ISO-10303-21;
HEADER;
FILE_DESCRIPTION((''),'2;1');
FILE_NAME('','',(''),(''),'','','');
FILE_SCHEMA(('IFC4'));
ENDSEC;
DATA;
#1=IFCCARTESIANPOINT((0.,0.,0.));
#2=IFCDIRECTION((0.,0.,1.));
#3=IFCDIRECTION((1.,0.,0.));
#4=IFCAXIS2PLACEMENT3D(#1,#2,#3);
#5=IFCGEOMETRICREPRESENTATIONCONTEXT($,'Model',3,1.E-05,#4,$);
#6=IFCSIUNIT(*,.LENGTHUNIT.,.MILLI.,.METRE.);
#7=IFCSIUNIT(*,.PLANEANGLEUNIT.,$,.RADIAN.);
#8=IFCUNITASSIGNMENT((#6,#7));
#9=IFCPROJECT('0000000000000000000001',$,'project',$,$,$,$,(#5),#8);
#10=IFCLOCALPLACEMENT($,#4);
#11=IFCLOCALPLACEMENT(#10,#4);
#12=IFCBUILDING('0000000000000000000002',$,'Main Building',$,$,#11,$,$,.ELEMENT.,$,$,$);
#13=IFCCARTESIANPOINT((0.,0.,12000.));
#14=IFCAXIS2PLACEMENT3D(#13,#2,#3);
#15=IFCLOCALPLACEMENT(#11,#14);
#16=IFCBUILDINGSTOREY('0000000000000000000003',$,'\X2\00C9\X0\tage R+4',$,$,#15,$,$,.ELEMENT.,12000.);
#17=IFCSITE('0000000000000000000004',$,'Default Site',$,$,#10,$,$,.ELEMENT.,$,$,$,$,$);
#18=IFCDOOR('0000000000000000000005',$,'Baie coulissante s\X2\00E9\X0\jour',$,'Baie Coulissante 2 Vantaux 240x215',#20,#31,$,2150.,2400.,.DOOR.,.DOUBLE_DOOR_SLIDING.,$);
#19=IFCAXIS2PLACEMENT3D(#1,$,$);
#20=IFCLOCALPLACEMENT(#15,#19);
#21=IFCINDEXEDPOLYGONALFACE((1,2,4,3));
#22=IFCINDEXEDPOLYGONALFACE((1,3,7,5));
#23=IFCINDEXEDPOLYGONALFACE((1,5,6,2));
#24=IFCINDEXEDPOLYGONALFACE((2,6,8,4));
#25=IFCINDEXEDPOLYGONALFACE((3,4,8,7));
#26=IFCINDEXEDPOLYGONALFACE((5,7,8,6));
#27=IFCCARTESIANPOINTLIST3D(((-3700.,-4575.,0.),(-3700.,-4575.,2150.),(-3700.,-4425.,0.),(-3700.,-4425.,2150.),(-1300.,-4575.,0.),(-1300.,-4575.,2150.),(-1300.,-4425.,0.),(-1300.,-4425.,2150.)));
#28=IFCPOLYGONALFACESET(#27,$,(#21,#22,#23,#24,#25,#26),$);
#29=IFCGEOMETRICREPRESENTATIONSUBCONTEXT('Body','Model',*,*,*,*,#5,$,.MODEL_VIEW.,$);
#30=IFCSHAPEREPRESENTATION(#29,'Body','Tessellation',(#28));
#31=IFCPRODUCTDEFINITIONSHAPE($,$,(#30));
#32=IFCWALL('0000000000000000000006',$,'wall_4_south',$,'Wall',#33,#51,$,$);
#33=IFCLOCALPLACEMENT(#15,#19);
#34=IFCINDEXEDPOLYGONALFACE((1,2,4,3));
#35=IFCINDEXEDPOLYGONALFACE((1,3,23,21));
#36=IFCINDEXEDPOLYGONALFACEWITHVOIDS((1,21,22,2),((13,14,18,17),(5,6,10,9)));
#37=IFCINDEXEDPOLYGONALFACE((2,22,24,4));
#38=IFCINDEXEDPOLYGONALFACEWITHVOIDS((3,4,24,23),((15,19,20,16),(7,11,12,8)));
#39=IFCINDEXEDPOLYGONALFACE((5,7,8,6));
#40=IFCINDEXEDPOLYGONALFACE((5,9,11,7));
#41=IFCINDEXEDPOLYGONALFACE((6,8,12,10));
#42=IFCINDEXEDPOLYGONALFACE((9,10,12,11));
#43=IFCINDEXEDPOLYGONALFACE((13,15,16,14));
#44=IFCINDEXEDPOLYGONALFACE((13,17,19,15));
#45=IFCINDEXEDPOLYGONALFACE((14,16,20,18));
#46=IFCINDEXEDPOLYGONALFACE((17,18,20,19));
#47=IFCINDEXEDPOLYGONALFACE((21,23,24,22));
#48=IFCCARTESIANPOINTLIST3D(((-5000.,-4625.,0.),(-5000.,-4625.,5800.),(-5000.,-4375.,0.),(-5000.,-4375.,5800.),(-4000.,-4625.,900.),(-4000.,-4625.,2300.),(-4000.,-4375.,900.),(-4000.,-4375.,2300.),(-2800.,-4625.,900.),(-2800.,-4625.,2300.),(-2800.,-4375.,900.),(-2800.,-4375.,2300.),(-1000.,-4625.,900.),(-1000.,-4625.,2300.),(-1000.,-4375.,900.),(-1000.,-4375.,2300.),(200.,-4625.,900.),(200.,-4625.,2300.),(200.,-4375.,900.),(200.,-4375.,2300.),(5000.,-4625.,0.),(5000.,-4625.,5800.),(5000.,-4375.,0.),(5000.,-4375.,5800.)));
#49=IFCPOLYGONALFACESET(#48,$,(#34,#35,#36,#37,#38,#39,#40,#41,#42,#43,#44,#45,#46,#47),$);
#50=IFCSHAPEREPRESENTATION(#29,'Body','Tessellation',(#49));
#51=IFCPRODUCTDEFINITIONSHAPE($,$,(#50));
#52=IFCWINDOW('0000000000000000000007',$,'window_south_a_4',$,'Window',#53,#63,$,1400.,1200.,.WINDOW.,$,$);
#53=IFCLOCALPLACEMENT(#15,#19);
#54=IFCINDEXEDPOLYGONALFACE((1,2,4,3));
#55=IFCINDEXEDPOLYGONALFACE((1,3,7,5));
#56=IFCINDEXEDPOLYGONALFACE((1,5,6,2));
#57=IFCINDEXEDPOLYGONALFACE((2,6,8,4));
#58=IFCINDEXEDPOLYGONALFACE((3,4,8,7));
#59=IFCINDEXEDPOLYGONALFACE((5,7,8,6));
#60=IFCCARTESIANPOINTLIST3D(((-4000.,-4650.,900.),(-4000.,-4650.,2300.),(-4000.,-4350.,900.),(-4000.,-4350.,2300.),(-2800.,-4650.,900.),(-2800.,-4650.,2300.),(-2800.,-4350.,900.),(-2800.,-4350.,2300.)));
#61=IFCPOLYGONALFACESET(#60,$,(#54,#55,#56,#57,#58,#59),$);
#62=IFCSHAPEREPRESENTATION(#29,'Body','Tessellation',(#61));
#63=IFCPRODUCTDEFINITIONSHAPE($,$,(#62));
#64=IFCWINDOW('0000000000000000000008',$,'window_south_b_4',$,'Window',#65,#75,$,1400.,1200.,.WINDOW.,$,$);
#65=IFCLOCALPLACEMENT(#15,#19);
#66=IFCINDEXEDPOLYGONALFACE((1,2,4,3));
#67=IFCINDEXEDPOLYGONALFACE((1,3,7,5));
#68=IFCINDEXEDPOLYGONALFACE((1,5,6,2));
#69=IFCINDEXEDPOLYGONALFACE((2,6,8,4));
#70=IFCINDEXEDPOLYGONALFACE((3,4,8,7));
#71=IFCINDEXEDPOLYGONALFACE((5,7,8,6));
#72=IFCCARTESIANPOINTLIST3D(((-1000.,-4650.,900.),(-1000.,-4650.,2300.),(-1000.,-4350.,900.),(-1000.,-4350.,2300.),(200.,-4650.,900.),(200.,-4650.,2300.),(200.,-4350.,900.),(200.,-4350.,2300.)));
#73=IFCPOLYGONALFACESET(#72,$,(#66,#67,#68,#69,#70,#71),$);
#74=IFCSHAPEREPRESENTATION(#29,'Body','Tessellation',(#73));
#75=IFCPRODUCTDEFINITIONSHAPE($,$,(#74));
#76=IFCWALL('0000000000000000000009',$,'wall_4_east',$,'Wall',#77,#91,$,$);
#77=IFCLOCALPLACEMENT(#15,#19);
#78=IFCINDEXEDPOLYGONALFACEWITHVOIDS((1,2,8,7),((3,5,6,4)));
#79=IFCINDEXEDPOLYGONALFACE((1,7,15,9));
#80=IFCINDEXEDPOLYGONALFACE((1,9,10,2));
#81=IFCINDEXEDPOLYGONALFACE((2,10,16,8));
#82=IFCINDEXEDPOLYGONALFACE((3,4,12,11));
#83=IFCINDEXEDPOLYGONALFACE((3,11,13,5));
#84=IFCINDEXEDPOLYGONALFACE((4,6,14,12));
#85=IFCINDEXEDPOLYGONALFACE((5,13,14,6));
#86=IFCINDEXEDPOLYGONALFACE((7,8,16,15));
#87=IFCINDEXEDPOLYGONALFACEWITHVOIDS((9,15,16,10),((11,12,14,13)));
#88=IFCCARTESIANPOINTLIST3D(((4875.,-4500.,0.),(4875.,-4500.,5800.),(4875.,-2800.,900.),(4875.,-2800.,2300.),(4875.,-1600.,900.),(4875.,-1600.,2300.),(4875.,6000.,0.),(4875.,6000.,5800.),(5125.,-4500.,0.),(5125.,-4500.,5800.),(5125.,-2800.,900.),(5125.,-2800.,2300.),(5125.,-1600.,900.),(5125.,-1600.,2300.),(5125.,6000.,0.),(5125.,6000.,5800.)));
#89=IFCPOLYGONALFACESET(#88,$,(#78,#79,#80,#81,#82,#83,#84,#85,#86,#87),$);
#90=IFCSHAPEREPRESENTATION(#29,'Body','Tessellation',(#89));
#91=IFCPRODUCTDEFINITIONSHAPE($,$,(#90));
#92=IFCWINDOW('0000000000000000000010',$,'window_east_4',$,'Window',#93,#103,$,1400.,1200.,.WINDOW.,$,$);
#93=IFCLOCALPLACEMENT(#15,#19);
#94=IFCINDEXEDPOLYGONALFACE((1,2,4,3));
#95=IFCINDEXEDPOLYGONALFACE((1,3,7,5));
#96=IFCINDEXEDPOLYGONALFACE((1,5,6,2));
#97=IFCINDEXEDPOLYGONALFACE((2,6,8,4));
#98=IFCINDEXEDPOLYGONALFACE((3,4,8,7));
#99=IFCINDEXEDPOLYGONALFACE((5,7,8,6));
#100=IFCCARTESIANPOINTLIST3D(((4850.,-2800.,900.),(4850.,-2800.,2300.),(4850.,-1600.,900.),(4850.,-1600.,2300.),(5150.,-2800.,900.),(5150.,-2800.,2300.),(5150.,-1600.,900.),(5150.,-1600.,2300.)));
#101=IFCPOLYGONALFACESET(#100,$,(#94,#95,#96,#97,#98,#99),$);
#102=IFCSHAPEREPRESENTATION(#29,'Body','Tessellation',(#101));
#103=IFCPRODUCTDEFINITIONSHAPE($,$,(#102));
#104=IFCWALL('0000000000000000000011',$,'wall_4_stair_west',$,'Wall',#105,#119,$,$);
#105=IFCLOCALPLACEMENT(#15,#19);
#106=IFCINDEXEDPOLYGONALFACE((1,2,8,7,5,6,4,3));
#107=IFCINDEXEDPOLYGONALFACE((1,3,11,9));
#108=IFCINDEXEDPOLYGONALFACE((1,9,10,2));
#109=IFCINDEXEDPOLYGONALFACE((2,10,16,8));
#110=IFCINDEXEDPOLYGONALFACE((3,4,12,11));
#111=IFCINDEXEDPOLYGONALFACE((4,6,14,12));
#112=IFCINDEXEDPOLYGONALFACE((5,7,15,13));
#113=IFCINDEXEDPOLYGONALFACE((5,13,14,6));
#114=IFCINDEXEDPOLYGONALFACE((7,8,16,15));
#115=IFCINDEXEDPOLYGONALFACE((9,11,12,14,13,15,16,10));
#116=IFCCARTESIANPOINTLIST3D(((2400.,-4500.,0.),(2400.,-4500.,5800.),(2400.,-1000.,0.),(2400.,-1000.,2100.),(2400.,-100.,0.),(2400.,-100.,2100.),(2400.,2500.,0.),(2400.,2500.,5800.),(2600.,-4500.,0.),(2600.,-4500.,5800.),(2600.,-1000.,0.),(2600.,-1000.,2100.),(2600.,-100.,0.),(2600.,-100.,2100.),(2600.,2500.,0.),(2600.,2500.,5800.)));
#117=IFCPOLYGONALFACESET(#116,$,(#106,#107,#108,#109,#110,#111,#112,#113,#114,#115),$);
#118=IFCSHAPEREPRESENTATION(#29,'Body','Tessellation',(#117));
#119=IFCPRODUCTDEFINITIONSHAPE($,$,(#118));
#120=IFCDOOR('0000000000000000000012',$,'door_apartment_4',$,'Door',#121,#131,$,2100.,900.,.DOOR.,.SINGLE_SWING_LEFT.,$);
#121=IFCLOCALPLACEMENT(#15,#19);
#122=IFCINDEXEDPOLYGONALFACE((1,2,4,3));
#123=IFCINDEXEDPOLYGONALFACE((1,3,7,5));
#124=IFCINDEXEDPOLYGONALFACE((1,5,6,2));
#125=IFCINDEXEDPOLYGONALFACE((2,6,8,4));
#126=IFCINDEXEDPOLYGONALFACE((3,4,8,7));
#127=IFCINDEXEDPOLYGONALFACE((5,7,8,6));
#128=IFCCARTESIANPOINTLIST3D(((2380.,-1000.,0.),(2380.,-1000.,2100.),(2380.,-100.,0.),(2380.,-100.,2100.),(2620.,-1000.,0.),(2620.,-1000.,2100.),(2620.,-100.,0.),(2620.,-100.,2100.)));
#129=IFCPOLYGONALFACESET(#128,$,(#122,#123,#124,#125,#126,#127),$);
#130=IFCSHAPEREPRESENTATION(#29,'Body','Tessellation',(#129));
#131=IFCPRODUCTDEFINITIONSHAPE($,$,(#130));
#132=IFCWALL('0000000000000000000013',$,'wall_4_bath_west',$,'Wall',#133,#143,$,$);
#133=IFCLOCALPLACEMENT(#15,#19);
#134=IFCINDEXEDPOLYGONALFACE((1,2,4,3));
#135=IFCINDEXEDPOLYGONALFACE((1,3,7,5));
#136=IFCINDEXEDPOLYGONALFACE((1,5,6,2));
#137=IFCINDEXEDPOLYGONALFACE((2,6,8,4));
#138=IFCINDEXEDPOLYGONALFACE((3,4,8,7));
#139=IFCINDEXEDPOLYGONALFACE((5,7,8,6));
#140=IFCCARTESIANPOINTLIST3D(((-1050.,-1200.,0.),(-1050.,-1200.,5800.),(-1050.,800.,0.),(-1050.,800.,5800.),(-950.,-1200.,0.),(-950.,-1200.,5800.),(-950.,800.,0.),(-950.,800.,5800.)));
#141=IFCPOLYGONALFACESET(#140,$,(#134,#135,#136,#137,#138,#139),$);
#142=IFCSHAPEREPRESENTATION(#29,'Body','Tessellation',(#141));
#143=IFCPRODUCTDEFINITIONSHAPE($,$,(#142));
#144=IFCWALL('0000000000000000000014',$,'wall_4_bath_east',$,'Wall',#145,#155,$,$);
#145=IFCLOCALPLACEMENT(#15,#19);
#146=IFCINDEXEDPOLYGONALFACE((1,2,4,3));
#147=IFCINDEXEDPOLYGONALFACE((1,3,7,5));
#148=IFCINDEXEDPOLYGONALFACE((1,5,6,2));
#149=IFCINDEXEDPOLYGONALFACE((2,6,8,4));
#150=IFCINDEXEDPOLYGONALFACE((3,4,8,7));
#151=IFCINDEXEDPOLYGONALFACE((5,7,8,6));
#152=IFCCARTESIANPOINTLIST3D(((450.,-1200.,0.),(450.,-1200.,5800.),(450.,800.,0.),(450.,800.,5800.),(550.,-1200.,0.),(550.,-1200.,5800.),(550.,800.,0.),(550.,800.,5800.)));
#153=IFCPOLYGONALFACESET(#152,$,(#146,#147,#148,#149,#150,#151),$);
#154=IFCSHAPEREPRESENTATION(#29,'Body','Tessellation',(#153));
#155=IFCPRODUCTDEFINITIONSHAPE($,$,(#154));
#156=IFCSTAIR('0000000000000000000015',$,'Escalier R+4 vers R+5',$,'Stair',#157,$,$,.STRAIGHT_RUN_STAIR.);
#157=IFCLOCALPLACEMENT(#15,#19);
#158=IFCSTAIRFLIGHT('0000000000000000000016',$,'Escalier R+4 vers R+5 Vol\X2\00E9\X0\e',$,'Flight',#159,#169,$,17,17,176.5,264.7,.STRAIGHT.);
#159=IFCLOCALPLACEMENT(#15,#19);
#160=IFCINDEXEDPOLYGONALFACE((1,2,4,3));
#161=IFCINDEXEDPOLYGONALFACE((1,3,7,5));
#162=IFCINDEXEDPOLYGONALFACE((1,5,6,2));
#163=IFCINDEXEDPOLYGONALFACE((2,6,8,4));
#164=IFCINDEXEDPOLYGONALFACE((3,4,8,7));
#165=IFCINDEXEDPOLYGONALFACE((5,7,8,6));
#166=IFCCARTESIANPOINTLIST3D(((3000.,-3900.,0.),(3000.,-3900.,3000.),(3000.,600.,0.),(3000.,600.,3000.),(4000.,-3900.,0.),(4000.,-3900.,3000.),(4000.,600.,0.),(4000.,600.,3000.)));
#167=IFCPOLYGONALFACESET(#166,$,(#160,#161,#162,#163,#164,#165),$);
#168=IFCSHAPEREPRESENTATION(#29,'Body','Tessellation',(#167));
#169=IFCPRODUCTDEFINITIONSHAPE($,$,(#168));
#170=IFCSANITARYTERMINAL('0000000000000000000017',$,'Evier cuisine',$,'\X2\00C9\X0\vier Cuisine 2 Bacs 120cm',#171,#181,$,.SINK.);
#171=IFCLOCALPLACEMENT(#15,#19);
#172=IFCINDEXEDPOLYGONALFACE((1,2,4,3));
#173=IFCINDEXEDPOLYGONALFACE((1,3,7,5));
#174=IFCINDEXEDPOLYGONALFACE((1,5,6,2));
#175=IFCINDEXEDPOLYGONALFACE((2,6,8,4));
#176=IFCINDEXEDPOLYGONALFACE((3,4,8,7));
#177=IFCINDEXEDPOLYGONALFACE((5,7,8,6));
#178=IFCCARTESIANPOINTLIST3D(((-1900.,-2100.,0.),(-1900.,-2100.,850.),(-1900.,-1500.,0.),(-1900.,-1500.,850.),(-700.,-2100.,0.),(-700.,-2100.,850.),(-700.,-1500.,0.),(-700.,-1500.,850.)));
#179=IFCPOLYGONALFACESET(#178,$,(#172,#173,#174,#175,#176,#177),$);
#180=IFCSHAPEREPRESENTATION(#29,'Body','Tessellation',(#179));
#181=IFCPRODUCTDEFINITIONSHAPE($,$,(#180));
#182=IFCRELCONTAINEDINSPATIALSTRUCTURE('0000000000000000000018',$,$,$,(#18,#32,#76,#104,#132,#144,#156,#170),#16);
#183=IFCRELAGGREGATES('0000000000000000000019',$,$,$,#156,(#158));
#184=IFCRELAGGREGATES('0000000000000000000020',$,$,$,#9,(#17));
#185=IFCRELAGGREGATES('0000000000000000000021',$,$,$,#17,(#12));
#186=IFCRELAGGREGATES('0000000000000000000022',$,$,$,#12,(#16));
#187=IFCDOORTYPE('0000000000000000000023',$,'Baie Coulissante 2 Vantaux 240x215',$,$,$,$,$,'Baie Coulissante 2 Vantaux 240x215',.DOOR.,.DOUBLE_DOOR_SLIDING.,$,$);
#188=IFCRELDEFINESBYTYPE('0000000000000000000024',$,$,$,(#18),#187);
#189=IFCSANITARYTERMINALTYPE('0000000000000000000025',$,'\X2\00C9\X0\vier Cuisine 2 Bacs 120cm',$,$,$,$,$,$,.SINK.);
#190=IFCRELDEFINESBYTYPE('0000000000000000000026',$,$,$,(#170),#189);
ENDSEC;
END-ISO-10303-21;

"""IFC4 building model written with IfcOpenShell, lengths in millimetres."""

from ifc_helpers import new_model, si_unit, frame, origin_with_axes, place, context, subcontext, project, spatial, polyline, outline, extrude, type_object, element, fill, aggregate, save


model = new_model("IFC4")

# Units and contexts
model_context = context("Model", 3, precision=1e-05, world=origin_with_axes())
body_context = subcontext(model_context, "Body", "Model", "MODEL_VIEW")
ifc_project = project(units=[si_unit("LENGTHUNIT", "METRE", prefix="MILLI"), si_unit("PLANEANGLEUNIT", "RADIAN")], contexts=[model_context])

# Site, building, storey
site_placement = place(None, origin_with_axes())
site = spatial("IfcSite", under=ifc_project, at=site_placement, Name="Default Site", CompositionType="ELEMENT")
building_placement = place(site_placement, origin_with_axes())
building = spatial("IfcBuilding", under=site, at=building_placement, Name="Main Building", CompositionType="ELEMENT")
storey_placement = place(building_placement, frame((0.0, 0.0, 12000.0), z_axis=(0.0, 0.0, 1.0), x_axis=(1.0, 0.0, 0.0)))
storey = spatial("IfcBuildingStorey", under=building, at=storey_placement, Name="Étage R+4", CompositionType="ELEMENT", Elevation=12000.0)

# Door
door_type = type_object("IfcDoorType", Name="Baie Coulissante 2 Vantaux 240x215", ElementType="Baie Coulissante 2 Vantaux 240x215", OperationType="DOUBLE_DOOR_SLIDING", PredefinedType="DOOR")
door_1_placement = place(storey_placement, frame((-2500.0, -4500.0, 0.0), z_axis=(0.0, 0.0, 1.0), x_axis=(1.0, 0.0, 0.0)))
element("IfcDoor", 1, at=door_1_placement, inside=storey, type_object=door_type, Name="Baie coulissante séjour", ObjectType="Baie Coulissante 2 Vantaux 240x215", OperationType="DOUBLE_DOOR_SLIDING", OverallHeight=2150.0, OverallWidth=2400.0, PredefinedType="DOOR", context=body_context, shape_type="SweptSolid", body=[
    extrude(outline(polyline([(-1200.0, -75.0), (1200.0, -75.0), (1200.0, 75.0), (-1200.0, 75.0), (-1200.0, -75.0)])), origin_with_axes(), (0.0, 0.0, 1.0), 2150.0),
])

# Wall, openings, windows
wall_1_placement = place(storey_placement, frame((-5000.0, -4500.0, 0.0), z_axis=(0.0, 0.0, 1.0), x_axis=(1.0, 0.0, 0.0)))
wall_1 = element("IfcWall", 2, at=wall_1_placement, inside=storey, Name="wall_4_south", ObjectType="Wall", context=body_context, shape_type="SweptSolid", body=[
    extrude(outline(polyline([(0.0, -125.0), (10000.0, -125.0), (10000.0, 125.0), (0.0, 125.0), (0.0, -125.0)])), origin_with_axes(), (0.0, 0.0, 1.0), 5800.0),
])
placement_1 = place(wall_1_placement, frame((1000.0, 0.0, 900.0), z_axis=(0.0, 0.0, 1.0), x_axis=(1.0, 0.0, 0.0)))
opening_1 = element("IfcOpeningElement", 3, at=placement_1, cuts=wall_1, PredefinedType="OPENING", context=body_context, shape_type="SweptSolid", body=[
    extrude(outline(polyline([(0.0, -150.0), (1200.0, -150.0), (1200.0, 150.0), (0.0, 150.0), (0.0, -150.0)])), origin_with_axes(), (0.0, 0.0, 1.0), 1400.0),
])
placement_2 = place(wall_1_placement, frame((4000.0, 0.0, 900.0), z_axis=(0.0, 0.0, 1.0), x_axis=(1.0, 0.0, 0.0)))
opening_2 = element("IfcOpeningElement", 4, at=placement_2, cuts=wall_1, PredefinedType="OPENING", context=body_context, shape_type="SweptSolid", body=[
    extrude(outline(polyline([(0.0, -150.0), (1200.0, -150.0), (1200.0, 150.0), (0.0, 150.0), (0.0, -150.0)])), origin_with_axes(), (0.0, 0.0, 1.0), 1400.0),
])
window_1 = element("IfcWindow", 5, at=placement_1, Name="window_south_a_4", ObjectType="Window", OverallHeight=1400.0, OverallWidth=1200.0, PredefinedType="WINDOW", context=body_context, shape_type="SweptSolid", body=[
    extrude(outline(polyline([(0.0, -150.0), (1200.0, -150.0), (1200.0, 150.0), (0.0, 150.0), (0.0, -150.0)])), origin_with_axes(), (0.0, 0.0, 1.0), 1400.0),
])
fill(opening_1, window_1)
window_2 = element("IfcWindow", 6, at=placement_2, Name="window_south_b_4", ObjectType="Window", OverallHeight=1400.0, OverallWidth=1200.0, PredefinedType="WINDOW", context=body_context, shape_type="SweptSolid", body=[
    extrude(outline(polyline([(0.0, -150.0), (1200.0, -150.0), (1200.0, 150.0), (0.0, 150.0), (0.0, -150.0)])), origin_with_axes(), (0.0, 0.0, 1.0), 1400.0),
])
fill(opening_2, window_2)

# Wall, opening, window
wall_2_placement = place(storey_placement, frame((5000.0, -4500.0, 0.0), z_axis=(0.0, 0.0, 1.0), x_axis=(0.0, 1.0, 0.0)))
wall_2 = element("IfcWall", 7, at=wall_2_placement, inside=storey, Name="wall_4_east", ObjectType="Wall", context=body_context, shape_type="SweptSolid", body=[
    extrude(outline(polyline([(0.0, -125.0), (10500.0, -125.0), (10500.0, 125.0), (0.0, 125.0), (0.0, -125.0)])), origin_with_axes(), (0.0, 0.0, 1.0), 5800.0),
])
placement_3 = place(wall_2_placement, frame((1700.0, 0.0, 900.0), z_axis=(0.0, 0.0, 1.0), x_axis=(1.0, 0.0, 0.0)))
opening_3 = element("IfcOpeningElement", 8, at=placement_3, cuts=wall_2, PredefinedType="OPENING", context=body_context, shape_type="SweptSolid", body=[
    extrude(outline(polyline([(0.0, -150.0), (1200.0, -150.0), (1200.0, 150.0), (0.0, 150.0), (0.0, -150.0)])), origin_with_axes(), (0.0, 0.0, 1.0), 1400.0),
])
window_3 = element("IfcWindow", 9, at=placement_3, Name="window_east_4", ObjectType="Window", OverallHeight=1400.0, OverallWidth=1200.0, PredefinedType="WINDOW", context=body_context, shape_type="SweptSolid", body=[
    extrude(outline(polyline([(0.0, -150.0), (1200.0, -150.0), (1200.0, 150.0), (0.0, 150.0), (0.0, -150.0)])), origin_with_axes(), (0.0, 0.0, 1.0), 1400.0),
])
fill(opening_3, window_3)

# Wall, opening, door
wall_3_placement = place(storey_placement, frame((2500.0, -4500.0, 0.0), z_axis=(0.0, 0.0, 1.0), x_axis=(0.0, 1.0, 0.0)))
wall_3 = element("IfcWall", 10, at=wall_3_placement, inside=storey, Name="wall_4_stair_west", ObjectType="Wall", context=body_context, shape_type="SweptSolid", body=[
    extrude(outline(polyline([(0.0, -100.0), (7000.0, -100.0), (7000.0, 100.0), (0.0, 100.0), (0.0, -100.0)])), origin_with_axes(), (0.0, 0.0, 1.0), 5800.0),
])
placement_4 = place(wall_3_placement, frame((3500.0, 0.0, 0.0), z_axis=(0.0, 0.0, 1.0), x_axis=(1.0, 0.0, 0.0)))
opening_4 = element("IfcOpeningElement", 11, at=placement_4, cuts=wall_3, PredefinedType="OPENING", context=body_context, shape_type="SweptSolid", body=[
    extrude(outline(polyline([(0.0, -120.0), (900.0, -120.0), (900.0, 120.0), (0.0, 120.0), (0.0, -120.0)])), origin_with_axes(), (0.0, 0.0, 1.0), 2100.0),
])
door_2 = element("IfcDoor", 12, at=placement_4, Name="door_apartment_4", ObjectType="Door", OperationType="SINGLE_SWING_LEFT", OverallHeight=2100.0, OverallWidth=900.0, PredefinedType="DOOR", context=body_context, shape_type="SweptSolid", body=[
    extrude(outline(polyline([(0.0, -120.0), (900.0, -120.0), (900.0, 120.0), (0.0, 120.0), (0.0, -120.0)])), origin_with_axes(), (0.0, 0.0, 1.0), 2100.0),
])
fill(opening_4, door_2)

# Walls
for number, where, z_axis, x_axis, name in (
    (13, (-1000.0, -1200.0, 0.0), (0.0, 0.0, 1.0), (0.0, 1.0, 0.0), "wall_4_bath_west"),
    (14, (500.0, -1200.0, 0.0), (0.0, 0.0, 1.0), (0.0, 1.0, 0.0), "wall_4_bath_east"),
):
    element("IfcWall", number, at=place(storey_placement, frame(where, z_axis=z_axis, x_axis=x_axis)), inside=storey, Name=name, ObjectType="Wall", context=body_context, shape_type="SweptSolid", body=[
        extrude(outline(polyline([(0.0, -50.0), (2000.0, -50.0), (2000.0, 50.0), (0.0, 50.0), (0.0, -50.0)])), origin_with_axes(), (0.0, 0.0, 1.0), 5800.0),
    ])

# Stair, stair flight
stair_placement = place(storey_placement, frame((3500.0, -3900.0, 0.0), z_axis=(0.0, 0.0, 1.0), x_axis=(0.0, 1.0, 0.0)))
stair = element("IfcStair", 15, at=stair_placement, inside=storey, Name="Escalier R+4 vers R+5", ObjectType="Stair", PredefinedType="STRAIGHT_RUN_STAIR")
stair_flight_placement = place(stair_placement, origin_with_axes())
stair_flight = element("IfcStairFlight", 16, at=stair_flight_placement, Name="Escalier R+4 vers R+5 Volée", ObjectType="Flight", NumberOfRisers=17, NumberOfTreads=17, PredefinedType="STRAIGHT", RiserHeight=176.5, TreadLength=264.7, context=body_context, shape_type="SweptSolid", body=[
    extrude(outline(polyline([(0.0, -500.0), (4500.0, -500.0), (4500.0, 500.0), (0.0, 500.0), (0.0, -500.0)])), origin_with_axes(), (0.0, 0.0, 1.0), 3000.0),
])
aggregate(stair, [stair_flight])

# Sanitary terminal
sanitary_terminal_type = type_object("IfcSanitaryTerminalType", Name="Évier Cuisine 2 Bacs 120cm", PredefinedType="SINK")
sanitary_terminal_placement = place(storey_placement, frame((-1300.0, -1800.0, 0.0), z_axis=(0.0, 0.0, 1.0), x_axis=(1.0, 0.0, 0.0)))
element("IfcSanitaryTerminal", 17, at=sanitary_terminal_placement, inside=storey, type_object=sanitary_terminal_type, Name="Evier cuisine", ObjectType="Évier Cuisine 2 Bacs 120cm", PredefinedType="SINK", context=body_context, shape_type="SweptSolid", body=[
    extrude(outline(polyline([(-600.0, -300.0), (600.0, -300.0), (600.0, 300.0), (-600.0, 300.0), (-600.0, -300.0)])), origin_with_axes(), (0.0, 0.0, 1.0), 850.0),
])

save(model, "model.ifc")
